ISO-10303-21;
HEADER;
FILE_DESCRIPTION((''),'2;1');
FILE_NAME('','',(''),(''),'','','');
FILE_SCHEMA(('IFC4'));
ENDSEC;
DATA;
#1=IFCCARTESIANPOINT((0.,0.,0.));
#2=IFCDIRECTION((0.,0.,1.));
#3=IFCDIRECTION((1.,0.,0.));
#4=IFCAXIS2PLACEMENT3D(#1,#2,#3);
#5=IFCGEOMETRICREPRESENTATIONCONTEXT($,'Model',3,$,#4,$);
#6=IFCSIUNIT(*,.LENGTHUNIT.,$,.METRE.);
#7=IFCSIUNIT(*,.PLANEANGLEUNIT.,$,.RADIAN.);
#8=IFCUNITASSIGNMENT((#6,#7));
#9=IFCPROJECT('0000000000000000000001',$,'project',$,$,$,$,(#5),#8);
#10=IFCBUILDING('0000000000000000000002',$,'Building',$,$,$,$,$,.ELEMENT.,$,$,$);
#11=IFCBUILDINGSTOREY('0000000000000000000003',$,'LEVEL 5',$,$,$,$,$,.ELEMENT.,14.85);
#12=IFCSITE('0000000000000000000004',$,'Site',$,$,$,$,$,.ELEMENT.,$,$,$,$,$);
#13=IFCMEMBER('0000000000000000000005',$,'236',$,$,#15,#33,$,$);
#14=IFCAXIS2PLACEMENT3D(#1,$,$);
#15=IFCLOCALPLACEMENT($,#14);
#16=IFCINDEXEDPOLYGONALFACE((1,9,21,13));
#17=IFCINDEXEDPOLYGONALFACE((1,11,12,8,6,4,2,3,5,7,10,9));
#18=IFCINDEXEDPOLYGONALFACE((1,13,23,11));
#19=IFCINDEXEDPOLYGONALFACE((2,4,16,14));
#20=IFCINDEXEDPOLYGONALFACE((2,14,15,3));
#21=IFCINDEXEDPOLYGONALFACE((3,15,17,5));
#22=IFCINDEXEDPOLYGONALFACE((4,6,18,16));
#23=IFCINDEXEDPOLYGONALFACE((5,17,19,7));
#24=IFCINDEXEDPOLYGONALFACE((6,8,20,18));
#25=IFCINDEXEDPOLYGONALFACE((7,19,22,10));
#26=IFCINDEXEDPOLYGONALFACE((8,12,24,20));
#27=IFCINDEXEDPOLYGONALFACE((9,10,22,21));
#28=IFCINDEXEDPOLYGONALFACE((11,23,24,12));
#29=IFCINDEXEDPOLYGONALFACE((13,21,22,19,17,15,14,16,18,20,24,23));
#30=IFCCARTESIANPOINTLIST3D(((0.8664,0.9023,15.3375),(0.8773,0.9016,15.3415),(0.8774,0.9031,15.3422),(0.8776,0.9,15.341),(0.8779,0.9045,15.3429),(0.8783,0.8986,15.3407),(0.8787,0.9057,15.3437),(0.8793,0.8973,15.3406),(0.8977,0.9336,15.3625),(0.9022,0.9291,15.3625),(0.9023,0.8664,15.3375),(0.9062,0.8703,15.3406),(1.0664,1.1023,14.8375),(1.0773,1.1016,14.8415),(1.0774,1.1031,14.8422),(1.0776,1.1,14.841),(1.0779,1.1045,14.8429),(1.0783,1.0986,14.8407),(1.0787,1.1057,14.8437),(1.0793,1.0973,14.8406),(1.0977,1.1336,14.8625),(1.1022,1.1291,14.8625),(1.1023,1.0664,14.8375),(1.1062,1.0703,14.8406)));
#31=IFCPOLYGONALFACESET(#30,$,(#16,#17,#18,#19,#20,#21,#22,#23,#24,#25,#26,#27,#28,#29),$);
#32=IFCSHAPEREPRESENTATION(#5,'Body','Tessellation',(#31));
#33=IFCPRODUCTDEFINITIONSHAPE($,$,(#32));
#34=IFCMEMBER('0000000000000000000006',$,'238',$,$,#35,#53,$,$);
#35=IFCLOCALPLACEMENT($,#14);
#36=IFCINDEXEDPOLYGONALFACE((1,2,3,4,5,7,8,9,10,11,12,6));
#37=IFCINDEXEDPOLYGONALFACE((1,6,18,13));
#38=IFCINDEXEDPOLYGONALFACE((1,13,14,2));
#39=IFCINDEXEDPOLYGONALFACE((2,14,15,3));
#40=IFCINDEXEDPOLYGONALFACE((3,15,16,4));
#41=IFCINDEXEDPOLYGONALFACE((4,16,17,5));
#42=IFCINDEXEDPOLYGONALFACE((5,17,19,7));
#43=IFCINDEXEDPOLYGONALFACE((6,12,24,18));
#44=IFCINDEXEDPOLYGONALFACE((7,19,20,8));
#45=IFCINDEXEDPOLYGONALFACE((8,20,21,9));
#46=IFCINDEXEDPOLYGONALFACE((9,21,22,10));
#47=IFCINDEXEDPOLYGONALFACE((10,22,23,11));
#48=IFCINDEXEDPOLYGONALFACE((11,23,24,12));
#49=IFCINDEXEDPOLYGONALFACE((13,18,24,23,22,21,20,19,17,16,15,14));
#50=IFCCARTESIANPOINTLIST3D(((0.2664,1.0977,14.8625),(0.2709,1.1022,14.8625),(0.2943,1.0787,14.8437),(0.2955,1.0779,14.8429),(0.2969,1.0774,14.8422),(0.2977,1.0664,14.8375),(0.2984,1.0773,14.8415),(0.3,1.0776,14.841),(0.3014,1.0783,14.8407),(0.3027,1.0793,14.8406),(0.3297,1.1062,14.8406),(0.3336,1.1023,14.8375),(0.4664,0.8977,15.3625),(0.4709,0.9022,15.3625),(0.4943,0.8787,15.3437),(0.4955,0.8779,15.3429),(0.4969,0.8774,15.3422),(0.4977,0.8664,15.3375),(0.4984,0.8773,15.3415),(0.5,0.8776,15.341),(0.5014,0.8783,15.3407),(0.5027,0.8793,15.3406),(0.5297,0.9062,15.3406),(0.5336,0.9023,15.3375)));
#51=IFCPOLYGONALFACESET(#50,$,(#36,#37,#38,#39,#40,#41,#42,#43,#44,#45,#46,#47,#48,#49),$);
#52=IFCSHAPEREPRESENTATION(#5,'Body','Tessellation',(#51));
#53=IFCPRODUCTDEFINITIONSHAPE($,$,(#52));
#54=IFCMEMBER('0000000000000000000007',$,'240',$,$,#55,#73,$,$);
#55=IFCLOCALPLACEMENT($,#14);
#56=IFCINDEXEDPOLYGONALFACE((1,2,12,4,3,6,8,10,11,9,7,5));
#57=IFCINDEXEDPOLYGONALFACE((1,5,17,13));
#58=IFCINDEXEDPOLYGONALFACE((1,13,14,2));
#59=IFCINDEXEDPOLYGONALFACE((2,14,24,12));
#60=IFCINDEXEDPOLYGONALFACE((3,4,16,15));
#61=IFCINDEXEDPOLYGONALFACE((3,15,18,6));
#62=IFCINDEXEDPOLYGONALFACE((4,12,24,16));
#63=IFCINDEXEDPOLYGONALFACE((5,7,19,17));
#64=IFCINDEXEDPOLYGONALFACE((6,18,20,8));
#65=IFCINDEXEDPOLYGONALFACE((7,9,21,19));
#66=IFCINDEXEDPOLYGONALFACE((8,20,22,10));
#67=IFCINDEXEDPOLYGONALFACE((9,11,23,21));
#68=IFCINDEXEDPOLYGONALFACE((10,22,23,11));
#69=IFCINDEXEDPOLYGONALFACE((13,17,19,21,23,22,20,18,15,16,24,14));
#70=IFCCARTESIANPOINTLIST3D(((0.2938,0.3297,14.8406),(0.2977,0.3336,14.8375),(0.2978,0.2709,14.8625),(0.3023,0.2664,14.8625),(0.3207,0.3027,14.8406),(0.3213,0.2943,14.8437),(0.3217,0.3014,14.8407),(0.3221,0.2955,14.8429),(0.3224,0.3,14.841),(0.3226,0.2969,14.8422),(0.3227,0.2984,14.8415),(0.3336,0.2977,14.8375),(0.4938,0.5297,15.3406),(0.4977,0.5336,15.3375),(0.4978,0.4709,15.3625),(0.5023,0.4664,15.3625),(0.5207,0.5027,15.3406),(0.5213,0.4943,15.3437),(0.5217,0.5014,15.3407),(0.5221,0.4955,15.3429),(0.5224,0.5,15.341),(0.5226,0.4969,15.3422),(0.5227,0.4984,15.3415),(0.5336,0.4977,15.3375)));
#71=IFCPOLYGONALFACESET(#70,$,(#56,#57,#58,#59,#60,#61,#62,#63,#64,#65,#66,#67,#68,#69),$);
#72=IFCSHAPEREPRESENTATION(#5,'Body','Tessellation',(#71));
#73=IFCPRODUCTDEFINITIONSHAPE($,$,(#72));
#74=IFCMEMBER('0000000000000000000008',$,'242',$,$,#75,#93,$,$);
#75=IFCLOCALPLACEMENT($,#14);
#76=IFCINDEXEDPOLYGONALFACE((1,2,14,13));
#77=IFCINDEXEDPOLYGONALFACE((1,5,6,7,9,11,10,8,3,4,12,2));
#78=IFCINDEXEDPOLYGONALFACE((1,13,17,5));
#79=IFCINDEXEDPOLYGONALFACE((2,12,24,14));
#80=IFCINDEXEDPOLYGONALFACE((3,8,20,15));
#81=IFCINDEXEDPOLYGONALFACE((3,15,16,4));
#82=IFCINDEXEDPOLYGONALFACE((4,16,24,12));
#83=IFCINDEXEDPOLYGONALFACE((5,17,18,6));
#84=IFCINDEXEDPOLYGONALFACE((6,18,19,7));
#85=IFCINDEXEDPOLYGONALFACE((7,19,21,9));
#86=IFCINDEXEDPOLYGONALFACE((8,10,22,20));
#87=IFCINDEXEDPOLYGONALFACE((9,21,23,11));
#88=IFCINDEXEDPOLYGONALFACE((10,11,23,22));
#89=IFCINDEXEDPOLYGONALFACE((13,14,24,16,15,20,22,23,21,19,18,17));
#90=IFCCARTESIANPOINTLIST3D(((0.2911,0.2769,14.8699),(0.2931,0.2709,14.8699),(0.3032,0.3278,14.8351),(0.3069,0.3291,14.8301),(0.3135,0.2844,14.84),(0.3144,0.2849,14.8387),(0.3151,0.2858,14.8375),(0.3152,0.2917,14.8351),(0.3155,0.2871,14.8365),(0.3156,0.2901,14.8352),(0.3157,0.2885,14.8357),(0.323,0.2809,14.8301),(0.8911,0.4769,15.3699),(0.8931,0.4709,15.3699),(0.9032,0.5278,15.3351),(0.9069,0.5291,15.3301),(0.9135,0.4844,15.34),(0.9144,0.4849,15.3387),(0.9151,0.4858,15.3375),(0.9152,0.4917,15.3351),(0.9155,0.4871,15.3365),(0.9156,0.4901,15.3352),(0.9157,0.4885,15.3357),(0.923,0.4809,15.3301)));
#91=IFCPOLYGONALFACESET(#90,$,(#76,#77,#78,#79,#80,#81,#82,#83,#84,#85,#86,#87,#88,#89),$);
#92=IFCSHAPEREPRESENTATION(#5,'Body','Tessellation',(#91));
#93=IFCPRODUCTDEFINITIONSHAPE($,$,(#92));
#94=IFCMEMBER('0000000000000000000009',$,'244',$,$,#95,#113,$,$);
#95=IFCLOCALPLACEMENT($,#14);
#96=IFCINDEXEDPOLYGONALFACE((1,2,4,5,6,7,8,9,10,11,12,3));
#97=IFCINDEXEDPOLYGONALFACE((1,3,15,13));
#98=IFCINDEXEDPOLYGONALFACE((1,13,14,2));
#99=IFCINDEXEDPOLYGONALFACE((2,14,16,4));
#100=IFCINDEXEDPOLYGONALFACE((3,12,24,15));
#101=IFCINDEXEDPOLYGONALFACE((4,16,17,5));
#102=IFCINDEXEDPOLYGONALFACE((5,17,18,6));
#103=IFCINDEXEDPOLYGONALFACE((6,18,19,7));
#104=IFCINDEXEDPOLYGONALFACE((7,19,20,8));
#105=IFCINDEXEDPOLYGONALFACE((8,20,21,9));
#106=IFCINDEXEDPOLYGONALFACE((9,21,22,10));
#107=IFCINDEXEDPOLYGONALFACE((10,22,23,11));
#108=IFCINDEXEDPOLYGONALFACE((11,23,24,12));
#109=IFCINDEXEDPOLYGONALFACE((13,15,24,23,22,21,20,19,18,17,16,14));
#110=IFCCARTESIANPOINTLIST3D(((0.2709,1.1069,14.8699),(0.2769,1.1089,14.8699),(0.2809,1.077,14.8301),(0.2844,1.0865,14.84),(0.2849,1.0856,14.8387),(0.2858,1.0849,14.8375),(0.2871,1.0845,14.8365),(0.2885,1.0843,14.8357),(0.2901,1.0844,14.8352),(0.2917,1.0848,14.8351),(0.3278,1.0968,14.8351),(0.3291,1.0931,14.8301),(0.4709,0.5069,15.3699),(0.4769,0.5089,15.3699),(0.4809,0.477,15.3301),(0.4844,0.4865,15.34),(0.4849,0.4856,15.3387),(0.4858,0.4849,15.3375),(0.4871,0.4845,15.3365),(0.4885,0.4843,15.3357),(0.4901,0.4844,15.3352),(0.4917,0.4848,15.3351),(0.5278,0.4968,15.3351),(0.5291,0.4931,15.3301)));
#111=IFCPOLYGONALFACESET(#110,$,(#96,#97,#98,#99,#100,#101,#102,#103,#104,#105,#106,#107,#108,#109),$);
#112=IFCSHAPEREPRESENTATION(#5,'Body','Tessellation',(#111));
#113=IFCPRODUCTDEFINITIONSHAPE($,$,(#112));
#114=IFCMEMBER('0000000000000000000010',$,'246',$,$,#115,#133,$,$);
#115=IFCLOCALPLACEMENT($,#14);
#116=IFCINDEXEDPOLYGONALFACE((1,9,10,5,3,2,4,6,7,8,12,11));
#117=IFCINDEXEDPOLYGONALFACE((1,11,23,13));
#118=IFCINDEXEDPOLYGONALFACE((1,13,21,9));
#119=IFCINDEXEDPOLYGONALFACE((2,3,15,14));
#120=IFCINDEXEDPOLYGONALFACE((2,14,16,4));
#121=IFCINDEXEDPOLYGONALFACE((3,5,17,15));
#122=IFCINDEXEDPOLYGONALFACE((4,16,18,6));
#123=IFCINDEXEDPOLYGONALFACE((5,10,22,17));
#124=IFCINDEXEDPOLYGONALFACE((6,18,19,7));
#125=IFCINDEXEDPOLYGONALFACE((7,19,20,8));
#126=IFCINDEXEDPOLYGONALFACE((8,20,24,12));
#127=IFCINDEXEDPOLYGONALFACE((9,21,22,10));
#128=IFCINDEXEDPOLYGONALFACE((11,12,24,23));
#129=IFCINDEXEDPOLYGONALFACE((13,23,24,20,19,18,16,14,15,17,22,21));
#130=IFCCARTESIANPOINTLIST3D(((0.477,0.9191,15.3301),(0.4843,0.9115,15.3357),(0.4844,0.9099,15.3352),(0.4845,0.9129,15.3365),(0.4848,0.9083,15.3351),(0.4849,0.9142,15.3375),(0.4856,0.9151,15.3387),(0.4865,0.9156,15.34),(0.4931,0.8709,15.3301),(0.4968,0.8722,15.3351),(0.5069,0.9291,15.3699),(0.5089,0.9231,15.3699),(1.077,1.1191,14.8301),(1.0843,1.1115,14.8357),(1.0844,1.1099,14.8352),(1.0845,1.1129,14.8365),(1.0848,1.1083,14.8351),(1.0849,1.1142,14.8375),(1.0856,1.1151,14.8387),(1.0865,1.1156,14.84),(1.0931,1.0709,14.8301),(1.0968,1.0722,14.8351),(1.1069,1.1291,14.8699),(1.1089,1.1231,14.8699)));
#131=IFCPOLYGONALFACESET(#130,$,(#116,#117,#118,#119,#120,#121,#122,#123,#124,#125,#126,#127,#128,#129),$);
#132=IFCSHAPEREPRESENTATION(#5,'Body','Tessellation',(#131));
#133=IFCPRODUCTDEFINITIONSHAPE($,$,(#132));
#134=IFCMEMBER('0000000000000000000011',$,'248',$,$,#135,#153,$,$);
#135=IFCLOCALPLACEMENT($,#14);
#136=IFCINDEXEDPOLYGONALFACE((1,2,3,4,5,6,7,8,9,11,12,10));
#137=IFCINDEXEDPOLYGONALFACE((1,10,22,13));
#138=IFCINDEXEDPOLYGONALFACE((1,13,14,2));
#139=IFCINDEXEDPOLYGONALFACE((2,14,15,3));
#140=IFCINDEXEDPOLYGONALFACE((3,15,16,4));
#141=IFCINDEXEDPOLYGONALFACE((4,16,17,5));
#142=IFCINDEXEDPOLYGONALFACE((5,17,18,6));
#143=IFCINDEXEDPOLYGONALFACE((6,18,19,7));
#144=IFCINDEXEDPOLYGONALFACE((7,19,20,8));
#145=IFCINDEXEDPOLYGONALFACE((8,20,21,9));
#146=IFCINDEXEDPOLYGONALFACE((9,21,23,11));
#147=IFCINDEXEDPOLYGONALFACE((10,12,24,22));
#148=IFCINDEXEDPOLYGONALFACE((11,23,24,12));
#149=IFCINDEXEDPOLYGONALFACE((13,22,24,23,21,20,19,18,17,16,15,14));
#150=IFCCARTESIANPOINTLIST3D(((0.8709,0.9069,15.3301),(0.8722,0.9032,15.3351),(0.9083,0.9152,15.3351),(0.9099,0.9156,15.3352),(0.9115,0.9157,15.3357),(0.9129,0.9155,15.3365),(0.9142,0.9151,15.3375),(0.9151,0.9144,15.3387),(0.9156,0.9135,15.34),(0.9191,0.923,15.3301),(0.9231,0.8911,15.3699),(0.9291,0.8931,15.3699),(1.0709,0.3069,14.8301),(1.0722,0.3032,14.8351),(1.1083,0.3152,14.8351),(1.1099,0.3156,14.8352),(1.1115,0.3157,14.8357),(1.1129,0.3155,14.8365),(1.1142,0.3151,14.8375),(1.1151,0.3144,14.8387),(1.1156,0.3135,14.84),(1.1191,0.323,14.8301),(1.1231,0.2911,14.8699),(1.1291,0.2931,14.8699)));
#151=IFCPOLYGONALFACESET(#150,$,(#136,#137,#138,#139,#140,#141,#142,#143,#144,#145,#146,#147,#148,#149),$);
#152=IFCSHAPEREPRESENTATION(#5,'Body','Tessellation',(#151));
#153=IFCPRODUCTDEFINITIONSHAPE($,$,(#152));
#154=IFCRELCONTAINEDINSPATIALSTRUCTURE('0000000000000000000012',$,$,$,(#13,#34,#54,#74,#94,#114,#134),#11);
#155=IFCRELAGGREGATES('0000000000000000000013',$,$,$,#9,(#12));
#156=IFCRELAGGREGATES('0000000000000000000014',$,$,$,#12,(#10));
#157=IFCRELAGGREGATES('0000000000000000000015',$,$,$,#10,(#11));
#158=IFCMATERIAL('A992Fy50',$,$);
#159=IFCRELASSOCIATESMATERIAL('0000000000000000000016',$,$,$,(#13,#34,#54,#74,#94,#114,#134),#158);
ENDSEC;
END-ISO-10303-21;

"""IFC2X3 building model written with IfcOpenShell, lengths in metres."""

from ifc_helpers import new_model, si_unit, frame, origin_with_axes, origin_2d_with_axis, place, context, project, spatial, l_section, extrude, material, element, save


model = new_model("IFC2X3")

# Units and contexts
model_context = context("Model", 3, world=origin_with_axes())
ifc_project = project(units=[si_unit("LENGTHUNIT", "METRE"), si_unit("PLANEANGLEUNIT", "RADIAN")], contexts=[model_context])

# Site, building, storey
site = spatial("IfcSite", under=ifc_project, Name="Site", CompositionType="ELEMENT")
building = spatial("IfcBuilding", under=site, Name="Building", CompositionType="ELEMENT")
storey = spatial("IfcBuildingStorey", under=building, Name="LEVEL 5", CompositionType="ELEMENT", Elevation=14.85)

# Shared definitions
ifc_material = material(Name="A992Fy50")

# Members
for number, where, z_axis, x_axis, name in (
    (1, (1.1, 1.1, 14.85), (-0.348155, -0.348155, 0.870388), (0.707107, -0.707107, 0.0), "236"),
    (2, (0.3, 1.1, 14.85), (0.348155, -0.348155, 0.870388), (0.707107, 0.707107, 0.0), "238"),
    (3, (0.3, 0.3, 14.85), (0.348155, 0.348155, 0.870388), (-0.707107, 0.707107, 0.0), "240"),
):
    element("IfcMember", number, at=place(None, frame(where, z_axis=z_axis, x_axis=x_axis)), inside=storey, material=ifc_material, Name=name, context=model_context, shape_type="SweptSolid", body=[
        extrude(l_section(Depth=0.0508, Width=0.0508, Thickness=0.0063, FilletRadius=0.0063, at=origin_2d_with_axis()), origin_with_axes(), (0.0, 0.0, 1.0), 0.5745),
    ])
for number, where, z_axis, x_axis, name in (
    (4, (0.3, 0.3, 14.85), (0.744208, 0.248069, 0.620174), (-0.316228, 0.948683, 0.0), "242"),
    (5, (0.3, 1.1, 14.85), (0.248069, -0.744208, 0.620174), (0.948683, 0.316228, 0.0), "244"),
    (6, (1.1, 1.1, 14.85), (-0.744208, -0.248069, 0.620174), (0.316228, -0.948683, 0.0), "246"),
    (7, (1.1, 0.3, 14.85), (-0.248069, 0.744208, 0.620174), (-0.948683, -0.316228, 0.0), "248"),
):
    element("IfcMember", number, at=place(None, frame(where, z_axis=z_axis, x_axis=x_axis)), inside=storey, material=ifc_material, Name=name, context=model_context, shape_type="SweptSolid", body=[
        extrude(l_section(Depth=0.0508, Width=0.0508, Thickness=0.0063, FilletRadius=0.0063, at=origin_2d_with_axis()), origin_with_axes(), (0.0, 0.0, 1.0), 0.8062),
    ])

save(model, "model.ifc")
